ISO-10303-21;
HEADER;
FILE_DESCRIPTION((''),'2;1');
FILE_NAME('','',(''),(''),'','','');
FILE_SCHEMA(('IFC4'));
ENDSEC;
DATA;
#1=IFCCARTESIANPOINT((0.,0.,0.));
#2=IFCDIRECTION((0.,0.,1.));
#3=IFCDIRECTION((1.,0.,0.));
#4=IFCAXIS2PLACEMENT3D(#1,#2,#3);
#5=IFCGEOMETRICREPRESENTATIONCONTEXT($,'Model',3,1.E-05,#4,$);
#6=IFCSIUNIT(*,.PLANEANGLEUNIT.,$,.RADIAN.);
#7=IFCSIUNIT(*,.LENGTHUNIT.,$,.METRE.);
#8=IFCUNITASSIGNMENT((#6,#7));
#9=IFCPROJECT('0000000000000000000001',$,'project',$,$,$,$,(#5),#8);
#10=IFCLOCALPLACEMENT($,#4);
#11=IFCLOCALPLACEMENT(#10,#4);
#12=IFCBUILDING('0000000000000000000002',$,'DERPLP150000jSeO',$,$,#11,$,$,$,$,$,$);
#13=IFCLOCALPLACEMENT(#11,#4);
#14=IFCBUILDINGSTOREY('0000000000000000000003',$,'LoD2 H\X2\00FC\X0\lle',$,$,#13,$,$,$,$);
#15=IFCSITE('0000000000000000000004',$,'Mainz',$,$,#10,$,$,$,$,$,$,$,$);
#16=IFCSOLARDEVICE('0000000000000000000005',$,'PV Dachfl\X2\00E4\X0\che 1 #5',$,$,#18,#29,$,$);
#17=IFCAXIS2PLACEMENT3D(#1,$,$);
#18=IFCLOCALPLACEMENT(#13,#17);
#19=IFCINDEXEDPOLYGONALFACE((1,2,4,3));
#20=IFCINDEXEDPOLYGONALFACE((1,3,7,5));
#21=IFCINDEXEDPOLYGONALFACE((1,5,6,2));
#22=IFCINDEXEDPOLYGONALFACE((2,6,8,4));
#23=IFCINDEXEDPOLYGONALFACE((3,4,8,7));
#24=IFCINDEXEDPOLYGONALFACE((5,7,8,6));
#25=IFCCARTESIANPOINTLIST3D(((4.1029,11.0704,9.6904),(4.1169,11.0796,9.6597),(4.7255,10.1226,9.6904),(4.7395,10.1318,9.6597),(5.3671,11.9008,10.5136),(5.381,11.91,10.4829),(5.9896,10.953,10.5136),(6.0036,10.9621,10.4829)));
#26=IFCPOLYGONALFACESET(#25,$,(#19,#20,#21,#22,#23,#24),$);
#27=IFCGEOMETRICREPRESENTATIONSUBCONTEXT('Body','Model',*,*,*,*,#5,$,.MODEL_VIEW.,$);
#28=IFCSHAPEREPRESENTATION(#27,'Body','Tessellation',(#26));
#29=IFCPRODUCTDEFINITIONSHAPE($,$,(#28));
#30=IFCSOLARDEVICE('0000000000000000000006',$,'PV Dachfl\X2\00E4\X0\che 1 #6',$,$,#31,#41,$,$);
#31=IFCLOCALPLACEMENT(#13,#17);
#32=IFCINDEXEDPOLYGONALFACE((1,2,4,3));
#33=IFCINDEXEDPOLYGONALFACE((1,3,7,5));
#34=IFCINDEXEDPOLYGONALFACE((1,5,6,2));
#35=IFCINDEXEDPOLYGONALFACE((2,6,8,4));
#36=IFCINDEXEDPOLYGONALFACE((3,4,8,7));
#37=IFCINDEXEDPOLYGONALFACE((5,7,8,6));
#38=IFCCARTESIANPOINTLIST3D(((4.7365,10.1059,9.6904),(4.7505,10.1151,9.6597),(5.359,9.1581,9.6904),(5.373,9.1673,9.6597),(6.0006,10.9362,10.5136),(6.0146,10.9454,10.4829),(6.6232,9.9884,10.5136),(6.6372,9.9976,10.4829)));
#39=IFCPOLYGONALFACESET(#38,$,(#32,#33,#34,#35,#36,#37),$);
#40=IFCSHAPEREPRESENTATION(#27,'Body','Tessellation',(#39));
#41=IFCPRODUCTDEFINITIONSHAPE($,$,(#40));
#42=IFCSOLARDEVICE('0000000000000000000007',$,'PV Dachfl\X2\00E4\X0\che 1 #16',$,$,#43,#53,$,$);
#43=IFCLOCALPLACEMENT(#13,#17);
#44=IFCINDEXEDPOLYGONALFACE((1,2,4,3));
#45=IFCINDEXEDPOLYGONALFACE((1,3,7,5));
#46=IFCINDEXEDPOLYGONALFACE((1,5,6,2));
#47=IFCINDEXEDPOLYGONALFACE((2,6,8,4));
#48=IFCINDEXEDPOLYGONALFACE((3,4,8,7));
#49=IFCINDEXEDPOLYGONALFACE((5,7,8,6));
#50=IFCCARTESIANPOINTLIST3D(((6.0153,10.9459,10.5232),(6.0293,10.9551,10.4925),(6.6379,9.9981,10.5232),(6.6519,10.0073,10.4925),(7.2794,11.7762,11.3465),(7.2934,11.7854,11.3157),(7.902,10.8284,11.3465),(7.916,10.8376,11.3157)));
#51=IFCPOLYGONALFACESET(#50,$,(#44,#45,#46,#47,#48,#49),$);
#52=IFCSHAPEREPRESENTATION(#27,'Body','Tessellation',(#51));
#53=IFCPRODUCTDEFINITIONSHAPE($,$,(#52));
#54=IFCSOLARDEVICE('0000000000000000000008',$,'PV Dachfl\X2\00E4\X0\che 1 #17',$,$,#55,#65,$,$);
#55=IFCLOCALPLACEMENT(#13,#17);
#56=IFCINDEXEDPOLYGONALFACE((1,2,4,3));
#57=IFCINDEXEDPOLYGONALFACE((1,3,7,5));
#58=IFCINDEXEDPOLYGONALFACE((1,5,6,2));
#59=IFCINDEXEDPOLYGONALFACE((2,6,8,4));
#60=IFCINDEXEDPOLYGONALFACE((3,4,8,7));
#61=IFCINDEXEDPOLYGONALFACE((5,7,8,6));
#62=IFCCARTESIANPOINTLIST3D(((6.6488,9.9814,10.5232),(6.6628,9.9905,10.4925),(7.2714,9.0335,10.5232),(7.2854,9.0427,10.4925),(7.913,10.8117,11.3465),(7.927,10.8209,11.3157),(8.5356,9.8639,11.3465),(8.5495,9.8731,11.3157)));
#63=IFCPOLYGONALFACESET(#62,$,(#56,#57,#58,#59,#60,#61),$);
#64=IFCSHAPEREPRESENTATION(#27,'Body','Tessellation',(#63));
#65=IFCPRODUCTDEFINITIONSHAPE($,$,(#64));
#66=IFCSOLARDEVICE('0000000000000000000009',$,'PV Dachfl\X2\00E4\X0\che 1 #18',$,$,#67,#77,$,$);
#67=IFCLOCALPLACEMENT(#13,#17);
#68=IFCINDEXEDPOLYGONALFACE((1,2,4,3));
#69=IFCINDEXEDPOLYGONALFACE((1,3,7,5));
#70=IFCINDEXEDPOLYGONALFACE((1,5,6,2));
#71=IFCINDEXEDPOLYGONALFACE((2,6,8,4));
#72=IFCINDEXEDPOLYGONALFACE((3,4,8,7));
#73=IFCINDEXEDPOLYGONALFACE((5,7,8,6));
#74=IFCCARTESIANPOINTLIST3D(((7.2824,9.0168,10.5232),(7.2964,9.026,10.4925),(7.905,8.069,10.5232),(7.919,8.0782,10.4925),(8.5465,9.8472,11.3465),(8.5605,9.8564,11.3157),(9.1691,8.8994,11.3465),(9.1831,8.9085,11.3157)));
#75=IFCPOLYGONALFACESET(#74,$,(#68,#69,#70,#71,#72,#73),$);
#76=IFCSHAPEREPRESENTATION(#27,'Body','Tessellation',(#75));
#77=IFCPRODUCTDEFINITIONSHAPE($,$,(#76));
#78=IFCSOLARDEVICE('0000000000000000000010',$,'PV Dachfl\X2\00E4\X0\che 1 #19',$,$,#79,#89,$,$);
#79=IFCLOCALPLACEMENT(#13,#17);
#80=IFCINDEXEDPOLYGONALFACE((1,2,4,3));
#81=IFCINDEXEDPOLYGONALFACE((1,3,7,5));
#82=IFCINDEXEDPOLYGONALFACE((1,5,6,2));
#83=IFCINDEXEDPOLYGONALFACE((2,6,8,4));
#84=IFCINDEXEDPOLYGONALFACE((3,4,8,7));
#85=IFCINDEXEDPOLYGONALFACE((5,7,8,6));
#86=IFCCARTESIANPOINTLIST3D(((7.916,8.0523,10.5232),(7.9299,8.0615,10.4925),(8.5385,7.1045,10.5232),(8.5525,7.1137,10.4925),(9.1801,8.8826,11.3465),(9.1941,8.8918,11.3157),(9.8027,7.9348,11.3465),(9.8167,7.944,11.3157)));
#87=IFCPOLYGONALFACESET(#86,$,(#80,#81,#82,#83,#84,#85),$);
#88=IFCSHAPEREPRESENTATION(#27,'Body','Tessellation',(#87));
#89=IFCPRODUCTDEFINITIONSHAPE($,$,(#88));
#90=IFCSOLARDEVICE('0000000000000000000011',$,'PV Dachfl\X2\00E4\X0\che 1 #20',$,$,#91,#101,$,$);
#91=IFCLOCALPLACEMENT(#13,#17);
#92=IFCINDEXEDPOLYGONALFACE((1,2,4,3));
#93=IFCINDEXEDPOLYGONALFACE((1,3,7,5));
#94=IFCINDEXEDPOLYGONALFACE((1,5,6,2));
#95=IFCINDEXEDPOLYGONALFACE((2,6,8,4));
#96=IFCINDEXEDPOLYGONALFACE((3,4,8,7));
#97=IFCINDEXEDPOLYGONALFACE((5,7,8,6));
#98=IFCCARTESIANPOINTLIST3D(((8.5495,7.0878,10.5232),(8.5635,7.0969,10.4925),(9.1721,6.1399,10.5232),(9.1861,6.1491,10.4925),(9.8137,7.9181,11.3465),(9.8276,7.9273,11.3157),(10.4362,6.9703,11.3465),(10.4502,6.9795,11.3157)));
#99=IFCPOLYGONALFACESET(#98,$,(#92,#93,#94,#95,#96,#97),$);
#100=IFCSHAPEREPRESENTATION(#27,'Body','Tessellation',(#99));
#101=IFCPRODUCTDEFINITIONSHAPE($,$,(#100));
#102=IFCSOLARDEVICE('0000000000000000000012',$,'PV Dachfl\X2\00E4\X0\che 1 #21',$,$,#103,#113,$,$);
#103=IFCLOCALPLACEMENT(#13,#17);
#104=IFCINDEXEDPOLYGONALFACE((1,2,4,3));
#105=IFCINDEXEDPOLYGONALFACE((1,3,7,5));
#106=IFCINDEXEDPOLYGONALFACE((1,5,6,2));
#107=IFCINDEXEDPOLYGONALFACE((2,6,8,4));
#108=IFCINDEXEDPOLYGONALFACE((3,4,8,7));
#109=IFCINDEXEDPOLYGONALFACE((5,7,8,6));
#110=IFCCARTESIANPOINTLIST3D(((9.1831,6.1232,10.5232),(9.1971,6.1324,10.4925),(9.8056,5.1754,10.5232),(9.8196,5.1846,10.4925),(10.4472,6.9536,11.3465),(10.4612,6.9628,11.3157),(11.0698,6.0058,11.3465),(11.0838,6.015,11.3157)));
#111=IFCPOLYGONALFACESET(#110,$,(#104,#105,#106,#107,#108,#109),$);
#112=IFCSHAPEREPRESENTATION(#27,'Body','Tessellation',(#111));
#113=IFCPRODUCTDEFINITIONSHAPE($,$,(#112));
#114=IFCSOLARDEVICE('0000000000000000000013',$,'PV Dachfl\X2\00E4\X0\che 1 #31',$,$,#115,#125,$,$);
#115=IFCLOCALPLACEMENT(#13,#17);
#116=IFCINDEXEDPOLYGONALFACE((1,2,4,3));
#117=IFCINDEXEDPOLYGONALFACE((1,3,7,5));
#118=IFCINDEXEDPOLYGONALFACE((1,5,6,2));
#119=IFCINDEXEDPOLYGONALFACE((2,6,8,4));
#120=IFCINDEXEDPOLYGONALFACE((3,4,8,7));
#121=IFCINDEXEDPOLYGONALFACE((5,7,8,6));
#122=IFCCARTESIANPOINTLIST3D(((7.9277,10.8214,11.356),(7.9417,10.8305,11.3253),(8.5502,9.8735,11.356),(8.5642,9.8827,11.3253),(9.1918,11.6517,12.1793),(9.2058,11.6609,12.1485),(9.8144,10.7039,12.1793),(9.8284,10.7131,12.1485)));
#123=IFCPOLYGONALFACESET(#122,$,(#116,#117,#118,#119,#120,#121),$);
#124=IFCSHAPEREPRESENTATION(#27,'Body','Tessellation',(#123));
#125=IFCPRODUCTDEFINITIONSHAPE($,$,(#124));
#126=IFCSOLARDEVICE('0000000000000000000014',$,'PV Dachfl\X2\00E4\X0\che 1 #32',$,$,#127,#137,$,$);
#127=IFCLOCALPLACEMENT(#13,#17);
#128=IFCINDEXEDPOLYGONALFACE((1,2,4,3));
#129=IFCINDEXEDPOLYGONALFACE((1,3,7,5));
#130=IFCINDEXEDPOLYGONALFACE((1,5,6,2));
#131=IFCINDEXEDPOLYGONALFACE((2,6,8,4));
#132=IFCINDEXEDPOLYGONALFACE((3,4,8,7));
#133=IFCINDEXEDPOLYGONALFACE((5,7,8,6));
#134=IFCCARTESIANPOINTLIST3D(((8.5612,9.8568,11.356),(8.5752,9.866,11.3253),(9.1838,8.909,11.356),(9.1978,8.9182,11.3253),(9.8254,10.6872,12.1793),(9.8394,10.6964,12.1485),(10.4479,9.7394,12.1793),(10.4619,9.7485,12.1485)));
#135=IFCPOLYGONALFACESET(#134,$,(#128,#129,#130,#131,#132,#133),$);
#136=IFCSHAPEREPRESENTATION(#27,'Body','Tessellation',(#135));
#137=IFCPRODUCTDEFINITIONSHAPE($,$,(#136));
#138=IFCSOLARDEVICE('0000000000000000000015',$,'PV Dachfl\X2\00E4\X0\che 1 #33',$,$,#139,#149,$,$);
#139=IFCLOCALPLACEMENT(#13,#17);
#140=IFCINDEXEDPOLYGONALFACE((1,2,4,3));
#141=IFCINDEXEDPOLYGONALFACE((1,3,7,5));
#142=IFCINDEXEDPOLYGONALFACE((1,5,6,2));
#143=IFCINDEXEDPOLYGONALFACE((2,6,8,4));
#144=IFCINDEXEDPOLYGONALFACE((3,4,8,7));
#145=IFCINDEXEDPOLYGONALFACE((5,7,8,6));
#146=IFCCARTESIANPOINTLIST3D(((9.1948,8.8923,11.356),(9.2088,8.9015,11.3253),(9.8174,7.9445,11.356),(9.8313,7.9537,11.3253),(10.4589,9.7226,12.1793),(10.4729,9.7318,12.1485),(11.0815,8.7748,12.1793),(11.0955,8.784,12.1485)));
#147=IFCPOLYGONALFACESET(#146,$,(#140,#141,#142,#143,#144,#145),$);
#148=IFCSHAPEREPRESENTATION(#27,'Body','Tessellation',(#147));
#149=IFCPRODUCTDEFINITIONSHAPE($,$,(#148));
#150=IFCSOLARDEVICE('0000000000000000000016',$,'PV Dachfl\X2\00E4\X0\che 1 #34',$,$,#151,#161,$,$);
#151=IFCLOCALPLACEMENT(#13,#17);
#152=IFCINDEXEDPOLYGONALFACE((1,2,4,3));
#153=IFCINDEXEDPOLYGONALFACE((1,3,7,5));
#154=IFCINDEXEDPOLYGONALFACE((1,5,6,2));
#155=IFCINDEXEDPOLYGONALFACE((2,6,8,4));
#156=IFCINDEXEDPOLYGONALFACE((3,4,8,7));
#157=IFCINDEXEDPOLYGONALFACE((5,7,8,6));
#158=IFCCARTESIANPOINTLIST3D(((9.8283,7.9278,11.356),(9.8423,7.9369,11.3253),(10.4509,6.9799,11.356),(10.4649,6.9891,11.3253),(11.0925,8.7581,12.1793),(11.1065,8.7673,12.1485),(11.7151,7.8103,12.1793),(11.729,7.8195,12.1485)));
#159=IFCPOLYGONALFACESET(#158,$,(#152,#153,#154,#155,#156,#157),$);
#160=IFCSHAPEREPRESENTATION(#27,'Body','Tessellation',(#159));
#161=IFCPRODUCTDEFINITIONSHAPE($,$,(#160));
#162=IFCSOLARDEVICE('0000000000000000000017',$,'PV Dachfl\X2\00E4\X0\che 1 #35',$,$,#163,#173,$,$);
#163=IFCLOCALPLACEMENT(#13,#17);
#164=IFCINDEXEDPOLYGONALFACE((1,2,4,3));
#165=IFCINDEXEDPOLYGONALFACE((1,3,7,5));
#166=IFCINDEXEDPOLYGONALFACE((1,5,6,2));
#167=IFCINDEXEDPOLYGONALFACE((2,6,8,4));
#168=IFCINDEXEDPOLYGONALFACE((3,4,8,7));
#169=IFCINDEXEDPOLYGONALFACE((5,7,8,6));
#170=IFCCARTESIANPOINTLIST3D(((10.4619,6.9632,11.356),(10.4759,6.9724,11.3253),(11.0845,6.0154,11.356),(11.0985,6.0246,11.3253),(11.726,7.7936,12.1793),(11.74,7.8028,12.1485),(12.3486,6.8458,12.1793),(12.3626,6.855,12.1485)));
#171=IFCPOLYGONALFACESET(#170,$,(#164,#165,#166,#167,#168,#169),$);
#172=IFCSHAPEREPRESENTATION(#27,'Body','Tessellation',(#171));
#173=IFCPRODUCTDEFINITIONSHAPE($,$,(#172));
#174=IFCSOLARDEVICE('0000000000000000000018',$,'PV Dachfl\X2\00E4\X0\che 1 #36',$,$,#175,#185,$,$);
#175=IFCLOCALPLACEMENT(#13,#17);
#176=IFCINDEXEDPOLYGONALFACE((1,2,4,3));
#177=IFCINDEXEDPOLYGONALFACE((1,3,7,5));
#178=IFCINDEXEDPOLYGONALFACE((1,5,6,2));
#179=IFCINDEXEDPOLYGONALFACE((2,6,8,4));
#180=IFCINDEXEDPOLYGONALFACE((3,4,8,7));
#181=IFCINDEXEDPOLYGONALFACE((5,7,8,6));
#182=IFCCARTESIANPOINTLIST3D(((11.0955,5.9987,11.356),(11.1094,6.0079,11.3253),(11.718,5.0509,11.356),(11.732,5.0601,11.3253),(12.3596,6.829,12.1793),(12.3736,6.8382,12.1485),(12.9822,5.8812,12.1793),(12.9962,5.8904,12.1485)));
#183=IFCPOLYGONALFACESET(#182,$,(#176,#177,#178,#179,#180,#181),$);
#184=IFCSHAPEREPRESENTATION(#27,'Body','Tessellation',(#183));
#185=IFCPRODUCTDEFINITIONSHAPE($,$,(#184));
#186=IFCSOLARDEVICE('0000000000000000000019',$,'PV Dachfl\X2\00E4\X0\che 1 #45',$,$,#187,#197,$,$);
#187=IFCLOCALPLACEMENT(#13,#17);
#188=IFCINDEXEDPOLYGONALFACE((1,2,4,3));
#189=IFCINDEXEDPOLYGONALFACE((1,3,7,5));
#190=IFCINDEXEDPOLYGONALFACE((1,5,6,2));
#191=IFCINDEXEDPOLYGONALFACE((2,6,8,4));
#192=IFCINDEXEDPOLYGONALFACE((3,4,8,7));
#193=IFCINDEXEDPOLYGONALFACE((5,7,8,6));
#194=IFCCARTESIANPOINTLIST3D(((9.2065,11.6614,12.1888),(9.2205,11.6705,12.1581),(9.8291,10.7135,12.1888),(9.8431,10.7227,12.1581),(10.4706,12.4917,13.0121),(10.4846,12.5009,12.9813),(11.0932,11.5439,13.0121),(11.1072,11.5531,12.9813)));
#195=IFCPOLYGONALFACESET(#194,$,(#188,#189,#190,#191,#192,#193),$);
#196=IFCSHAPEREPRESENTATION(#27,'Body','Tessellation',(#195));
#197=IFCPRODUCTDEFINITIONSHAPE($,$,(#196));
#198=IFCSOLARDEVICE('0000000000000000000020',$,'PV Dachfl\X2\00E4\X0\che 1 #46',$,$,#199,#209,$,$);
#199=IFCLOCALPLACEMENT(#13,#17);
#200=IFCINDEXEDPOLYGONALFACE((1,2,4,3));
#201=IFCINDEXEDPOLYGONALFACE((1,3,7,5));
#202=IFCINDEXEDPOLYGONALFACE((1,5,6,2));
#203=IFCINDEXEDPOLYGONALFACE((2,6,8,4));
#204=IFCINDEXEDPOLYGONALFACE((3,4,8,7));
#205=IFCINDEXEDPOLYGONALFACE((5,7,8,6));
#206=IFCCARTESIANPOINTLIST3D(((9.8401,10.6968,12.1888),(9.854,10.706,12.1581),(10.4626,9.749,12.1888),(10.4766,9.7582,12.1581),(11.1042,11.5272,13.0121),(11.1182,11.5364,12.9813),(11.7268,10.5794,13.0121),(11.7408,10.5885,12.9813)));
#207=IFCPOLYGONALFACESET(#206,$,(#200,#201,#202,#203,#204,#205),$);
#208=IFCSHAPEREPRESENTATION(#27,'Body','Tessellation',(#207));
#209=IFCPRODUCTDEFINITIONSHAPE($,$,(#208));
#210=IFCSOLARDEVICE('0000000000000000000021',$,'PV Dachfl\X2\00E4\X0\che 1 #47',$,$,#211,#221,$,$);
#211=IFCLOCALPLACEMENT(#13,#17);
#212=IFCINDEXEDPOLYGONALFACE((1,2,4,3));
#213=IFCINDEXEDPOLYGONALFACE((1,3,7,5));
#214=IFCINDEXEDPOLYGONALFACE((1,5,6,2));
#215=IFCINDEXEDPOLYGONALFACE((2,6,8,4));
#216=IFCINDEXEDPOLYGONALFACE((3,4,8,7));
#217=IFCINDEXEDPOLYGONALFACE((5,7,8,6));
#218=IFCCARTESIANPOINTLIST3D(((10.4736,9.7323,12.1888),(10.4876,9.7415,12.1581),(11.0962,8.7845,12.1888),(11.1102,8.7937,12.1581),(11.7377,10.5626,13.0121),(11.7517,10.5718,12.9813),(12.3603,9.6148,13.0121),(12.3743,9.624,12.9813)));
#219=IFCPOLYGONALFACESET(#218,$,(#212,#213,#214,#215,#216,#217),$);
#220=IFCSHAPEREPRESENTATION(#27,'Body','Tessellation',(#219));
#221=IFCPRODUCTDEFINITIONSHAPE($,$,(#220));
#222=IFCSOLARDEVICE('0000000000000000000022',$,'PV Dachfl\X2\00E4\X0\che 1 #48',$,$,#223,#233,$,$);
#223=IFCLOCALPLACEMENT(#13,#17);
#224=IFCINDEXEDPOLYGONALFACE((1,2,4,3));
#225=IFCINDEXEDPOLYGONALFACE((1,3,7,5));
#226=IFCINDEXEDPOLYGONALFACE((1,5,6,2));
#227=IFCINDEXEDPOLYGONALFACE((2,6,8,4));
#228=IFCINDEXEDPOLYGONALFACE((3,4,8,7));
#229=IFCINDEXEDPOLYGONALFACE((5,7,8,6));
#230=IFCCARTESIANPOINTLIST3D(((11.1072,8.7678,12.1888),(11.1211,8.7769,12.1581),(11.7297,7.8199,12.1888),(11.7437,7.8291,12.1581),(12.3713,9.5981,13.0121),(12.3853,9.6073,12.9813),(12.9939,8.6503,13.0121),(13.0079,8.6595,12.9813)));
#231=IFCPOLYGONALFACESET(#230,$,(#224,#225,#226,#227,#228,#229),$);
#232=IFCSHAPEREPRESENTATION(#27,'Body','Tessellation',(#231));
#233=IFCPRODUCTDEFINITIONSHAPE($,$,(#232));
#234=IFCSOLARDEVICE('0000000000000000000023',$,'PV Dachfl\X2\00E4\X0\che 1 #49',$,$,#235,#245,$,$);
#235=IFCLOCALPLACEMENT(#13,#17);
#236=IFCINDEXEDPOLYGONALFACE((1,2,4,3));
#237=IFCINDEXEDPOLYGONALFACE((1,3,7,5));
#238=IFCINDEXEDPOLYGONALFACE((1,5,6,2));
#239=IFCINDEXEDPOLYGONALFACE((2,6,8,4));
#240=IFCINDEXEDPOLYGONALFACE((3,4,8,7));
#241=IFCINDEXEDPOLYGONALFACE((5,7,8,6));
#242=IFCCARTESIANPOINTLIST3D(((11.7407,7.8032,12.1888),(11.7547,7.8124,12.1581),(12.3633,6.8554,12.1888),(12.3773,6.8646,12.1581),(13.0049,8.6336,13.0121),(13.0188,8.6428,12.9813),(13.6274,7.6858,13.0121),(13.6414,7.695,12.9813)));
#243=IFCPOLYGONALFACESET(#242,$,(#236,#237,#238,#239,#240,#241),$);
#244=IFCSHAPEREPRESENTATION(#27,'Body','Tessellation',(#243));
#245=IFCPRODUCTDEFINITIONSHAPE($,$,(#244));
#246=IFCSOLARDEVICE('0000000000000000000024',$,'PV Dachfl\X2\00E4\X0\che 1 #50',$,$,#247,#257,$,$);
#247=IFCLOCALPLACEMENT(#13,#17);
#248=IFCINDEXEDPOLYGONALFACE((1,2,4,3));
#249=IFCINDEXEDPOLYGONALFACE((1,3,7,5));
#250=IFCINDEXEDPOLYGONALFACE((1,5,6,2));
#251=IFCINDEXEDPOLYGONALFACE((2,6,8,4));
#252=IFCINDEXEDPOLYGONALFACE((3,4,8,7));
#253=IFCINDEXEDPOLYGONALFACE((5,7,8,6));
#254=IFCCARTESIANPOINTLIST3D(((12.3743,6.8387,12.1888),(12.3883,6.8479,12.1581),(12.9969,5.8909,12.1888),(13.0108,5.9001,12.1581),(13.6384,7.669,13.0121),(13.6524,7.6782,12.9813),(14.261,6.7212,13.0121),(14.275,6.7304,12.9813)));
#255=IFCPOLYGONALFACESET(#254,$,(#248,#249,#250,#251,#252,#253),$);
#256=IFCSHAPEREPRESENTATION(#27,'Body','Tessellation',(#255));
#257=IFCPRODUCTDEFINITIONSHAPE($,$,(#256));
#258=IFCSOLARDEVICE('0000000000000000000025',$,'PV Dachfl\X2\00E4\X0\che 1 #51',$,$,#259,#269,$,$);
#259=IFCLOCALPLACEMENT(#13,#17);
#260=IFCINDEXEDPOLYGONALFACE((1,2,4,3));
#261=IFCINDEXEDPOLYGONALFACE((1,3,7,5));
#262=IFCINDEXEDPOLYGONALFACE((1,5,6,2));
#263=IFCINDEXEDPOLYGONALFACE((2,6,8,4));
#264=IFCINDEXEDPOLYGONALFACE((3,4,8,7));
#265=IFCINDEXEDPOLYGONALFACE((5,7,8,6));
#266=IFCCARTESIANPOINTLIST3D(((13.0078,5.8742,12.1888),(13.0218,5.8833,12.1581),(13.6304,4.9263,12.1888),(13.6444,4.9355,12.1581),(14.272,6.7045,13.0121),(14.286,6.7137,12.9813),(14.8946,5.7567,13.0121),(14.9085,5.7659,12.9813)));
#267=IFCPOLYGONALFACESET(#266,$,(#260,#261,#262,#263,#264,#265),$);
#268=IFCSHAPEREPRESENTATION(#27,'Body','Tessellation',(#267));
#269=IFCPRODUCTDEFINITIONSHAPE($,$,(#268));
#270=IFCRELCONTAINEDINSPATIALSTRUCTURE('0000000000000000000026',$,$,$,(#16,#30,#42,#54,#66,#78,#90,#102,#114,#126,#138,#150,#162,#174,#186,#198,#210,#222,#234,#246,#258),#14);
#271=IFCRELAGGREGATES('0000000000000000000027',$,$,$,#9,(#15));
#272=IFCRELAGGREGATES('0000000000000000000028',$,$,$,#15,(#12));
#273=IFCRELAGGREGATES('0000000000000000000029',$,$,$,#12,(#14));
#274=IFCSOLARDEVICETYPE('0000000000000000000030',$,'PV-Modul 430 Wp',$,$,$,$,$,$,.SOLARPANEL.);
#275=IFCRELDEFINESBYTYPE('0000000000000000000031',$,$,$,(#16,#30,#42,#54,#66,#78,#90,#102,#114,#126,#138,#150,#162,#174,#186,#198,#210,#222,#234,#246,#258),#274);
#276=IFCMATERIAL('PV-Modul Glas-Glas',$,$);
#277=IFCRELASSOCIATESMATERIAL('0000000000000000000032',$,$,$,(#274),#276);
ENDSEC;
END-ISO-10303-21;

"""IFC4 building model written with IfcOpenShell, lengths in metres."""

from ifc_helpers import new_model, si_unit, frame, frame_2d, origin, origin_with_axes, place, context, subcontext, project, spatial, rectangle, extrude, source, transform, mapped, material, type_object, type_shapes, element, save


model = new_model("IFC4")

# Units and contexts
model_context = context("Model", 3, precision=1e-05, world=origin_with_axes())
body_context = subcontext(model_context, "Body", "Model", "MODEL_VIEW")
ifc_project = project(units=[si_unit("PLANEANGLEUNIT", "RADIAN"), si_unit("LENGTHUNIT", "METRE")], contexts=[model_context])

# Site, building, storey
site_placement = place(None, origin_with_axes())
site = spatial("IfcSite", under=ifc_project, at=site_placement, Name="Mainz")
building_placement = place(site_placement, origin_with_axes())
building = spatial("IfcBuilding", under=site, at=building_placement, Name="DERPLP150000jSeO")
storey_placement = place(building_placement, origin_with_axes())
storey = spatial("IfcBuildingStorey", under=building, at=storey_placement, Name="LoD2 Hülle")

# Solar devices
ifc_material = material(Name="PV-Modul Glas-Glas")
solar_device_type = type_object("IfcSolarDeviceType", Name="PV-Modul 430 Wp", PredefinedType="SOLARPANEL", material=ifc_material)
shared_shape = source(origin_with_axes(), body_context, "Body", "SweptSolid", [
    extrude(rectangle(XDim=1.722, YDim=1.134, at=frame_2d((0.861, 0.567))), origin(), (0.0, 0.0, 1.0), 0.035),
])
type_shapes(solar_device_type, [shared_shape])
for number, where, z_axis, x_axis, name in (
    (1, (4.7395, 10.1318, 9.6597), (-0.399585, -0.262469, 0.878318), (0.734113, 0.482204, 0.478077), "PV Dachfläche 1 #5"),
    (2, (5.373, 9.1673, 9.6597), (-0.399585, -0.262469, 0.878318), (0.734113, 0.482204, 0.478077), "PV Dachfläche 1 #6"),
    (3, (6.6519, 10.0073, 10.4925), (-0.399585, -0.262469, 0.878318), (0.734113, 0.482204, 0.478077), "PV Dachfläche 1 #16"),
    (4, (7.2854, 9.0427, 10.4925), (-0.399585, -0.262469, 0.878318), (0.734113, 0.482204, 0.478077), "PV Dachfläche 1 #17"),
    (5, (7.919, 8.0782, 10.4925), (-0.399585, -0.262469, 0.878318), (0.734113, 0.482204, 0.478077), "PV Dachfläche 1 #18"),
    (6, (8.5525, 7.1137, 10.4925), (-0.399585, -0.262469, 0.878318), (0.734113, 0.482204, 0.478077), "PV Dachfläche 1 #19"),
    (7, (9.1861, 6.1491, 10.4925), (-0.399585, -0.262469, 0.878318), (0.734113, 0.482204, 0.478077), "PV Dachfläche 1 #20"),
    (8, (9.8196, 5.1846, 10.4925), (-0.399585, -0.262469, 0.878318), (0.734113, 0.482204, 0.478077), "PV Dachfläche 1 #21"),
    (9, (8.5642, 9.8827, 11.3253), (-0.399585, -0.262469, 0.878318), (0.734113, 0.482204, 0.478077), "PV Dachfläche 1 #31"),
    (10, (9.1978, 8.9182, 11.3253), (-0.399585, -0.262469, 0.878318), (0.734113, 0.482204, 0.478077), "PV Dachfläche 1 #32"),
    (11, (9.8313, 7.9537, 11.3253), (-0.399585, -0.262469, 0.878318), (0.734113, 0.482204, 0.478077), "PV Dachfläche 1 #33"),
    (12, (10.4649, 6.9891, 11.3253), (-0.399585, -0.262469, 0.878318), (0.734113, 0.482204, 0.478077), "PV Dachfläche 1 #34"),
    (13, (11.0985, 6.0246, 11.3253), (-0.399585, -0.262469, 0.878318), (0.734113, 0.482204, 0.478077), "PV Dachfläche 1 #35"),
    (14, (11.732, 5.0601, 11.3253), (-0.399585, -0.262469, 0.878318), (0.734113, 0.482204, 0.478077), "PV Dachfläche 1 #36"),
    (15, (9.8431, 10.7227, 12.1581), (-0.399585, -0.262469, 0.878318), (0.734113, 0.482204, 0.478077), "PV Dachfläche 1 #45"),
    (16, (10.4766, 9.7582, 12.1581), (-0.399585, -0.262469, 0.878318), (0.734113, 0.482204, 0.478077), "PV Dachfläche 1 #46"),
    (17, (11.1102, 8.7937, 12.1581), (-0.399585, -0.262469, 0.878318), (0.734113, 0.482204, 0.478077), "PV Dachfläche 1 #47"),
    (18, (11.7437, 7.8291, 12.1581), (-0.399585, -0.262469, 0.878318), (0.734113, 0.482204, 0.478077), "PV Dachfläche 1 #48"),
    (19, (12.3773, 6.8646, 12.1581), (-0.399585, -0.262469, 0.878318), (0.734113, 0.482204, 0.478077), "PV Dachfläche 1 #49"),
    (20, (13.0108, 5.9001, 12.1581), (-0.399585, -0.262469, 0.878318), (0.734113, 0.482204, 0.478077), "PV Dachfläche 1 #50"),
    (21, (13.6444, 4.9355, 12.1581), (-0.399585, -0.262469, 0.878318), (0.734113, 0.482204, 0.478077), "PV Dachfläche 1 #51"),
):
    element("IfcSolarDevice", number, at=place(storey_placement, frame(where, z_axis=z_axis, x_axis=x_axis)), inside=storey, type_object=solar_device_type, Name=name, context=body_context, shape_type="MappedRepresentation", body=[
        mapped(shared_shape, transform((0.0, 0.0, 0.0), x_axis=(1.0, 0.0, 0.0), y_axis=(0.0, 1.0, 0.0), z_axis=(0.0, 0.0, 1.0), scale=1.0)),
    ])

save(model, "model.ifc")
